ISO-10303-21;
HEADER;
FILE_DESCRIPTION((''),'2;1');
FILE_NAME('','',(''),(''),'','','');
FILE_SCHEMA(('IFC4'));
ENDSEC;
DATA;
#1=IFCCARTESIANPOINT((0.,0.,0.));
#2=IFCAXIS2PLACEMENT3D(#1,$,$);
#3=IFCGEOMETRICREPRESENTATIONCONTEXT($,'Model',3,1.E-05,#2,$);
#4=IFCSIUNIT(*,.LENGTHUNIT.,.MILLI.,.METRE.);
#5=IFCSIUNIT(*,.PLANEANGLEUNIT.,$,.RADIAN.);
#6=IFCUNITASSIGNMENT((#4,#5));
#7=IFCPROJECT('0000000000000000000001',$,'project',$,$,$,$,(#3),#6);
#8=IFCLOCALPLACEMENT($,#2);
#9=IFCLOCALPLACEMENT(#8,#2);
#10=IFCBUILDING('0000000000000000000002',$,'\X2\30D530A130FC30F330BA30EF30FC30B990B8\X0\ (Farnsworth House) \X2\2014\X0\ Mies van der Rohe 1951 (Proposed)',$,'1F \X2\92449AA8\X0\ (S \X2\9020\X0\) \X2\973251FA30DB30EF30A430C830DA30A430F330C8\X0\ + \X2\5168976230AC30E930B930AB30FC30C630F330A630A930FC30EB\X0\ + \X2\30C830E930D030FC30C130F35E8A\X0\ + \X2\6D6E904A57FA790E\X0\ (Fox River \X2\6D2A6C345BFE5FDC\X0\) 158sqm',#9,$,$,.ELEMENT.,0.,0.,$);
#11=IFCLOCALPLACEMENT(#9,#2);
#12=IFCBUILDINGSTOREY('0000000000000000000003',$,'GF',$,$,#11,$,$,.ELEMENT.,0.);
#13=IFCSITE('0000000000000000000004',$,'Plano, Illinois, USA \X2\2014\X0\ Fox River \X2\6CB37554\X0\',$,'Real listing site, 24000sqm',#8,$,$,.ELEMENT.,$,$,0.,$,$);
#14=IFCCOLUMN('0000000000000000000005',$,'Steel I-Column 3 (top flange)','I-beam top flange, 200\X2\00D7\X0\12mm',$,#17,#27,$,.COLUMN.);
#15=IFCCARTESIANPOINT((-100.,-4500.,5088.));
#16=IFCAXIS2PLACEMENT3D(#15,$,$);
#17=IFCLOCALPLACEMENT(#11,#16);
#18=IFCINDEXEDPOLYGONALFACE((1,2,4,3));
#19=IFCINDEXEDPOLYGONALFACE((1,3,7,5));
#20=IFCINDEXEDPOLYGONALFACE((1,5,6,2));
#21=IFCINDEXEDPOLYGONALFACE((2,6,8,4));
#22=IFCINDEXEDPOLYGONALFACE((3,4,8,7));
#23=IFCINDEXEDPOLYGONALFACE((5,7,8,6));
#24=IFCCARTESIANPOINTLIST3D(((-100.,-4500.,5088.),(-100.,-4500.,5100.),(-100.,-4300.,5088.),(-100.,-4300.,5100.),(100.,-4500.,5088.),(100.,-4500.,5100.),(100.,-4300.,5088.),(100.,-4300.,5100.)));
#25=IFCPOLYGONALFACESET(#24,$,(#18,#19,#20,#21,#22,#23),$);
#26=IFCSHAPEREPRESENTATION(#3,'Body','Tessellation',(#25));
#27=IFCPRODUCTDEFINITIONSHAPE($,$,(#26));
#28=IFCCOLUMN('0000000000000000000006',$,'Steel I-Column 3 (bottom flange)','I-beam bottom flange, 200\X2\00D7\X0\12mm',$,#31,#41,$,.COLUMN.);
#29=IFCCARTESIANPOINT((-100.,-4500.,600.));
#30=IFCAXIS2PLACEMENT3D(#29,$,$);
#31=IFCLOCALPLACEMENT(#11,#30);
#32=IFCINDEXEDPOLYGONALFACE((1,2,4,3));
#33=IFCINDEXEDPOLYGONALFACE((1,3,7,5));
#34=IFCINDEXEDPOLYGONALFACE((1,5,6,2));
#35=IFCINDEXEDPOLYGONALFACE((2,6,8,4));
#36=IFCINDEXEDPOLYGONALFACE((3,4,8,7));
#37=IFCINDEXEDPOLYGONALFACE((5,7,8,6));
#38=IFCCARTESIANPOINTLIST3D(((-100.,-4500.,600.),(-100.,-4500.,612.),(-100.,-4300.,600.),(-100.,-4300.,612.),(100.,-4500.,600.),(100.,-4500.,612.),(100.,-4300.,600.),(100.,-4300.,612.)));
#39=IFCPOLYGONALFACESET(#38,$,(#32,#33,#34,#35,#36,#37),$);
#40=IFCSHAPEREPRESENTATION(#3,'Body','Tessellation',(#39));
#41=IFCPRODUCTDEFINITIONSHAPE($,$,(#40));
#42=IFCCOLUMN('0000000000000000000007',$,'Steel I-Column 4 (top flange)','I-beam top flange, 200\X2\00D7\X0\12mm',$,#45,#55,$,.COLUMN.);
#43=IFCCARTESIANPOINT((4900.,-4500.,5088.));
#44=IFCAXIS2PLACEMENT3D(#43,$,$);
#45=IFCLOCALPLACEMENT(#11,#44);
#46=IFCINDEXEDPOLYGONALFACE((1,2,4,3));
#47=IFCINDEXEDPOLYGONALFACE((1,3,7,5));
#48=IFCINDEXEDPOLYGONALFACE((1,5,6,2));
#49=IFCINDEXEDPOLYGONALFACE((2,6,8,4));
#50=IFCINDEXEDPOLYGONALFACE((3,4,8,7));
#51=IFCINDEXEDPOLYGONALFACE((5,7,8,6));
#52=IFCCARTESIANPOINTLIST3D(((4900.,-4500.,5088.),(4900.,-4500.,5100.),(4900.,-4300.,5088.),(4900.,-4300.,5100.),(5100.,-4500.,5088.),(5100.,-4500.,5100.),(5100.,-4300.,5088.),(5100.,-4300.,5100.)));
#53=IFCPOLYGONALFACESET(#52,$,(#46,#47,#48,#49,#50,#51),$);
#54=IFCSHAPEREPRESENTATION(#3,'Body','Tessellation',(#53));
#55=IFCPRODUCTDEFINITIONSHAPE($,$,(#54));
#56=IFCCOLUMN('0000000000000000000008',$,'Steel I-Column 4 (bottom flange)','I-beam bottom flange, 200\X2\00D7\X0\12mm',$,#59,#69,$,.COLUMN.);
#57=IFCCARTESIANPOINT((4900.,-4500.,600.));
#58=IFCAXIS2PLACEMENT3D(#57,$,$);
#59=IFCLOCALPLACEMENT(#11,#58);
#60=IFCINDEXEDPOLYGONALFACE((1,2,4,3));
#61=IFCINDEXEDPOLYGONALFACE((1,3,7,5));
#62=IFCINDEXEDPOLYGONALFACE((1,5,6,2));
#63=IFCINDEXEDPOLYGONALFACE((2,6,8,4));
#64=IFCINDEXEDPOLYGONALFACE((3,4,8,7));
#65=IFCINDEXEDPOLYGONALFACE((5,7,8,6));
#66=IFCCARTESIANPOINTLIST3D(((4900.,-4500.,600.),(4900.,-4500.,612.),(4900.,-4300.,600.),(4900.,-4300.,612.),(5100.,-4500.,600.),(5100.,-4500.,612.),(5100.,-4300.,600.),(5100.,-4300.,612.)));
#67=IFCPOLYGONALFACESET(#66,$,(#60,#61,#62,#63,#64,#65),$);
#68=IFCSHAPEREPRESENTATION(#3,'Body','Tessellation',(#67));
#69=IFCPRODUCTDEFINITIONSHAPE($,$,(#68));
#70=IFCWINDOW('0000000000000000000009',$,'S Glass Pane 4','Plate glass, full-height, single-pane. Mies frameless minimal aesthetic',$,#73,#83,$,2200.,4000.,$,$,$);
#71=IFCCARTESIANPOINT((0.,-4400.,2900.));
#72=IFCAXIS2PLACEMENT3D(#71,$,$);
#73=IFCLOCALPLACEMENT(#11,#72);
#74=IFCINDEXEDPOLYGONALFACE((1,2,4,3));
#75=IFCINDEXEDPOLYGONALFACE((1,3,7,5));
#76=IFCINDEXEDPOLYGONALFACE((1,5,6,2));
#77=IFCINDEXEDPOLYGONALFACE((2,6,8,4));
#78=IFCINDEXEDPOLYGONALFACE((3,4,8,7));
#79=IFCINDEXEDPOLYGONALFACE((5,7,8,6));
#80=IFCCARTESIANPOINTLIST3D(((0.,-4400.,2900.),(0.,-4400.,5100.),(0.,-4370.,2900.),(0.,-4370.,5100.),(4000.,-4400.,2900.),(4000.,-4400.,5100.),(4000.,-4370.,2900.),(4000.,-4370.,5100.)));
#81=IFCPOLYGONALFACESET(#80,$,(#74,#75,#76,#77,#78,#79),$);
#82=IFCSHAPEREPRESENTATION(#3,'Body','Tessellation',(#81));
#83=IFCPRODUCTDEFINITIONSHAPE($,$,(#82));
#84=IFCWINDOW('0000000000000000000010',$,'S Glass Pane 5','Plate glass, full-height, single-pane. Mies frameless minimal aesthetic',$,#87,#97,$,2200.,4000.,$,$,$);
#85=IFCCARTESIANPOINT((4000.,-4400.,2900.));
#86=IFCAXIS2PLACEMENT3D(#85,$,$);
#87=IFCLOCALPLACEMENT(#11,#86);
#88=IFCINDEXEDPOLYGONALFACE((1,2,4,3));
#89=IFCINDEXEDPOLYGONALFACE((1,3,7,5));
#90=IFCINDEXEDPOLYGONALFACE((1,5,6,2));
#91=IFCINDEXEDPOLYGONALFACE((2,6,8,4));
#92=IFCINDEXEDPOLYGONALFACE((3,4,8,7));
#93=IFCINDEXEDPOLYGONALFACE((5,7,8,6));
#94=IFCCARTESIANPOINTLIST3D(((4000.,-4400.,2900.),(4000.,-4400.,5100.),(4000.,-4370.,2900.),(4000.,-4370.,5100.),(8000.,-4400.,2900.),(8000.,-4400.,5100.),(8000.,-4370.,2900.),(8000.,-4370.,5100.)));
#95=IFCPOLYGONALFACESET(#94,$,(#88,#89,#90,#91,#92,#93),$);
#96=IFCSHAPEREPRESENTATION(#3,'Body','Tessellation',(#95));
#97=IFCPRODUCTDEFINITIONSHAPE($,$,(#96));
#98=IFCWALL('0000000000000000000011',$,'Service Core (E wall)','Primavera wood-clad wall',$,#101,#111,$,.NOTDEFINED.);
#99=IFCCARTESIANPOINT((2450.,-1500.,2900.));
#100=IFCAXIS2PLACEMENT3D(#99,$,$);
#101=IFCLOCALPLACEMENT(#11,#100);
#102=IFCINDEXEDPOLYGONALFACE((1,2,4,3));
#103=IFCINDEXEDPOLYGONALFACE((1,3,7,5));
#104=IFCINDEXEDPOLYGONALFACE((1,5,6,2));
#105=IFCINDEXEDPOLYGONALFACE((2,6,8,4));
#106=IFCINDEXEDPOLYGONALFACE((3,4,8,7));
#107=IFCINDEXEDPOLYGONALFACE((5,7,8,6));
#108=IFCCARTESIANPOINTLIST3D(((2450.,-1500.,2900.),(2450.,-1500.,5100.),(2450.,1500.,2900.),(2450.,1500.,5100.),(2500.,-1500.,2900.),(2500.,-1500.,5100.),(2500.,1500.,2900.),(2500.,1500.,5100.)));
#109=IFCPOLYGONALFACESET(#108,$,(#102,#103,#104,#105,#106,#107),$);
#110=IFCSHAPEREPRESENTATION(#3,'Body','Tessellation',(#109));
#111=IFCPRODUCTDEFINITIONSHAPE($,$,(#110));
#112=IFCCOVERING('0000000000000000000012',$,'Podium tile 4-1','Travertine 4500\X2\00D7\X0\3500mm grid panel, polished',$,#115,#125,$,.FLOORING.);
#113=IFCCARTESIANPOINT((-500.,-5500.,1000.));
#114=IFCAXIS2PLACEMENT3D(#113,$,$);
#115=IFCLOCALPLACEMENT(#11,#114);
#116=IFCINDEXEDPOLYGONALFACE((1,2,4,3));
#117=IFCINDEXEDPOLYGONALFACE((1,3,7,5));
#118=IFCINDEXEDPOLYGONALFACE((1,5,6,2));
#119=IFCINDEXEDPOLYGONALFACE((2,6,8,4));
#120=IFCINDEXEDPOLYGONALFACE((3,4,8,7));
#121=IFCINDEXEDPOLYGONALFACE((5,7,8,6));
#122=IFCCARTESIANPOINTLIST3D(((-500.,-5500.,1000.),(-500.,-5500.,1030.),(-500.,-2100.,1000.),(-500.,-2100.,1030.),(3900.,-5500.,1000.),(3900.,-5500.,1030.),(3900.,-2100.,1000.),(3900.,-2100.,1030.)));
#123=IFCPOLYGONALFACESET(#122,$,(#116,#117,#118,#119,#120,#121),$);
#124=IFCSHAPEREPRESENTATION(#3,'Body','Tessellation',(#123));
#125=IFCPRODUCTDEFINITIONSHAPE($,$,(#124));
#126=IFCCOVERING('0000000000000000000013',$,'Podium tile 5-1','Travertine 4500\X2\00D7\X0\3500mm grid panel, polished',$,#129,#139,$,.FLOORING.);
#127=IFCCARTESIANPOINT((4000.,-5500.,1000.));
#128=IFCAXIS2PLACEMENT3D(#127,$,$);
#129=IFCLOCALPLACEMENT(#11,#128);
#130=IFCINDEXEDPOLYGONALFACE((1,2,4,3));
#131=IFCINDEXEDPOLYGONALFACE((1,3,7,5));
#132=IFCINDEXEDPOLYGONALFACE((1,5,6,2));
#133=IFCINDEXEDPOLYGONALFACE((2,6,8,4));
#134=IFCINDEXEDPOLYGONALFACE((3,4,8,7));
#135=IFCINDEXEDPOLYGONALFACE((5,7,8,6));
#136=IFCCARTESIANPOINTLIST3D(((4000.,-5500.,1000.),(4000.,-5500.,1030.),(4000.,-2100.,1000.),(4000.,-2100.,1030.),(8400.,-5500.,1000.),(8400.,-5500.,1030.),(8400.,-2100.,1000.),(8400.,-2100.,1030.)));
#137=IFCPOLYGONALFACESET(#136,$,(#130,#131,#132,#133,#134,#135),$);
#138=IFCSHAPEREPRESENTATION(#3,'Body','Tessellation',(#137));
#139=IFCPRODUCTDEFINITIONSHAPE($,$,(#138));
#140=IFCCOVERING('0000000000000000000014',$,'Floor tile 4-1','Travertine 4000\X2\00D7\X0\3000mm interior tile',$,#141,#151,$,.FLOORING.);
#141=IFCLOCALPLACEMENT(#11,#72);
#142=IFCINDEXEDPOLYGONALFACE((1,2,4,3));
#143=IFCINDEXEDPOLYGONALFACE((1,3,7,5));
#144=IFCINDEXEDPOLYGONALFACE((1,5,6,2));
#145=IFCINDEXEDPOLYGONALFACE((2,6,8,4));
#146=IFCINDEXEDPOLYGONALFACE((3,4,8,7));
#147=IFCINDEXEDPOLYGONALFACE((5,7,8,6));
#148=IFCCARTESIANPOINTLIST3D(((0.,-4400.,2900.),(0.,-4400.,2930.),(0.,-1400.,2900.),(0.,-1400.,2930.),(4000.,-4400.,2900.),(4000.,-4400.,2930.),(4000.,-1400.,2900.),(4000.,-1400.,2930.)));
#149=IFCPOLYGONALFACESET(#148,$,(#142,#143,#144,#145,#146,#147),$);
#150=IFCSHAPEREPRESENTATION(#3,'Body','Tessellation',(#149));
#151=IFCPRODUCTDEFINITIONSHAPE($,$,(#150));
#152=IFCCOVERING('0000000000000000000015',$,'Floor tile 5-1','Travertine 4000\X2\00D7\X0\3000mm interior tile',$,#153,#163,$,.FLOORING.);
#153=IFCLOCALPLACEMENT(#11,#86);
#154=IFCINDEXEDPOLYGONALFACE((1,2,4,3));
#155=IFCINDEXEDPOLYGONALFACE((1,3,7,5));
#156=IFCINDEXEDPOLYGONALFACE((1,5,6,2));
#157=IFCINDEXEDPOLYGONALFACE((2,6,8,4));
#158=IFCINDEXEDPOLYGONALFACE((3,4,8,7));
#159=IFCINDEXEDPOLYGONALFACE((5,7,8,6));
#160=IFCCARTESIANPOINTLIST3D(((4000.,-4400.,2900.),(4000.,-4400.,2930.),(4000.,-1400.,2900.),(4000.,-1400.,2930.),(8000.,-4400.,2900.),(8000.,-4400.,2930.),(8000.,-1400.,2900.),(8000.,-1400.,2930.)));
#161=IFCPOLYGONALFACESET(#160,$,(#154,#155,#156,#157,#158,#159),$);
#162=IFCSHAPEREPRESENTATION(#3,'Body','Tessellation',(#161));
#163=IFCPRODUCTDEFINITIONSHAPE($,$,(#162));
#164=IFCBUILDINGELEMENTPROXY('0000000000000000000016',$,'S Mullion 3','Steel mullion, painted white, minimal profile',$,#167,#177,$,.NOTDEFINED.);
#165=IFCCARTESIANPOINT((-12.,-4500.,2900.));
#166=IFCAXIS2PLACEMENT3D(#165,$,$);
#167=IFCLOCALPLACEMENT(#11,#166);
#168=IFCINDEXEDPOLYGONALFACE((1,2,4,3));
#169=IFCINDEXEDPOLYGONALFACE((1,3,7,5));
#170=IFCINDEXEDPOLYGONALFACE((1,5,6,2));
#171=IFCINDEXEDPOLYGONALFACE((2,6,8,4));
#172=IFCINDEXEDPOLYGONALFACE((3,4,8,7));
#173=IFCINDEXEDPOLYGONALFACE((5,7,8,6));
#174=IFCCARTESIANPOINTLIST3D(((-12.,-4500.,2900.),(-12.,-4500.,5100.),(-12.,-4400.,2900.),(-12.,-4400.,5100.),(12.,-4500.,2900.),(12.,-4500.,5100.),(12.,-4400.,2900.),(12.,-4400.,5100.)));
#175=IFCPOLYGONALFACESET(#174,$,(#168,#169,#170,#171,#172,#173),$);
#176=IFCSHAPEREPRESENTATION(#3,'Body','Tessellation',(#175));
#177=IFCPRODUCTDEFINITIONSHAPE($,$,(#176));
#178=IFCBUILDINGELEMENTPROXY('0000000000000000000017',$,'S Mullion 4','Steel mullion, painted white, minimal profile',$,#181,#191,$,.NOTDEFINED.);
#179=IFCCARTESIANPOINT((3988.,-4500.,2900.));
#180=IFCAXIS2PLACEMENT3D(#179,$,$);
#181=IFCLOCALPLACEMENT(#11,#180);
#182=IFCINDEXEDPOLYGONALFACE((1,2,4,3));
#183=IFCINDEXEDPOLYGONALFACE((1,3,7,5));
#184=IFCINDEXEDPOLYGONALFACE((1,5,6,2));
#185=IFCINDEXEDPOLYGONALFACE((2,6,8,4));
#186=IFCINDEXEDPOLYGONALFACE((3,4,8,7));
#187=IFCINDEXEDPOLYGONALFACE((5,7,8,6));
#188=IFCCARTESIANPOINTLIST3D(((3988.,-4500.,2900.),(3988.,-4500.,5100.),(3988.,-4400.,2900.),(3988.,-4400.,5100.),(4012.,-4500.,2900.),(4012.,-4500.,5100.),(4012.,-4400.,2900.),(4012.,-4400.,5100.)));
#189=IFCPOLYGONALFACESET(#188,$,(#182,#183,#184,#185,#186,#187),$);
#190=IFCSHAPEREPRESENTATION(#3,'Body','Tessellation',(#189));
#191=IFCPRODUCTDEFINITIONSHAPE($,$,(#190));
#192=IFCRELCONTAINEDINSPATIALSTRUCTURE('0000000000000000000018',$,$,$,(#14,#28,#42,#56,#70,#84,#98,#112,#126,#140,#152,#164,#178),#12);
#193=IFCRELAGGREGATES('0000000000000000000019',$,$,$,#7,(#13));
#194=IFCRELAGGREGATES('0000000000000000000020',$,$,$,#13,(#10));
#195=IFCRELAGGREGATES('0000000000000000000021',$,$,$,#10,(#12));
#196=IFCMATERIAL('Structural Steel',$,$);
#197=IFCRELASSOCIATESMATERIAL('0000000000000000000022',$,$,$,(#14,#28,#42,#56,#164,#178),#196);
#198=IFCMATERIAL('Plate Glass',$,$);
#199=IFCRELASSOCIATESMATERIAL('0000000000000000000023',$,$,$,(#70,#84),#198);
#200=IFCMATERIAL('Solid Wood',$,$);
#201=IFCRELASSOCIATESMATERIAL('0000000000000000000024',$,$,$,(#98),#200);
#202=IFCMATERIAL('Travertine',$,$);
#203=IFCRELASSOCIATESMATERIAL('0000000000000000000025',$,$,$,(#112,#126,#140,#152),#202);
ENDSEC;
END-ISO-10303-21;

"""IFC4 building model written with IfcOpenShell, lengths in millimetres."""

from ifc_helpers import new_model, si_unit, frame, frame_2d, origin, place, context, project, spatial, rectangle, extrude, material, element, save


model = new_model("IFC4")

# Units and contexts
model_context = context("Model", 3, precision=1e-05, world=origin())
ifc_project = project(units=[si_unit("LENGTHUNIT", "METRE", prefix="MILLI"), si_unit("PLANEANGLEUNIT", "RADIAN")], contexts=[model_context])

# Site, building, storey
site_placement = place(None, origin())
site = spatial("IfcSite", under=ifc_project, at=site_placement, Name="Plano, Illinois, USA — Fox River 河畔", ObjectType="Real listing site, 24000sqm", CompositionType="ELEMENT", RefElevation=0.0)
building_placement = place(site_placement, origin())
building = spatial("IfcBuilding", under=site, at=building_placement, Name="ファーンズワース邸 (Farnsworth House) — Mies van der Rohe 1951 (Proposed)", ObjectType="1F 鉄骨 (S 造) 露出ホワイトペイント + 全面ガラスカーテンウォール + トラバーチン床 + 浮遊基礎 (Fox River 洪水対応) 158sqm", CompositionType="ELEMENT", ElevationOfRefHeight=0.0, ElevationOfTerrain=0.0)
storey_placement = place(building_placement, origin())
storey = spatial("IfcBuildingStorey", under=building, at=storey_placement, Name="GF", CompositionType="ELEMENT", Elevation=0.0)

# Columns
ifc_material_1 = material(Name="Structural Steel")
column_1_placement = place(storey_placement, frame((-100.0, -4500.0, 5088.0)))
element("IfcColumn", 1, at=column_1_placement, inside=storey, material=ifc_material_1, Name="Steel I-Column 3 (top flange)", Description="I-beam top flange, 200×12mm", PredefinedType="COLUMN", context=model_context, shape_type="SweptSolid", body=[
    extrude(rectangle(XDim=200.0, YDim=200.0, at=frame_2d((100.0, 100.0))), frame((-100.0, -4500.0, 5088.0)), (0.0, 0.0, 1.0), 12.0),
])
column_2_placement = place(storey_placement, frame((-100.0, -4500.0, 600.0)))
element("IfcColumn", 2, at=column_2_placement, inside=storey, material=ifc_material_1, Name="Steel I-Column 3 (bottom flange)", Description="I-beam bottom flange, 200×12mm", PredefinedType="COLUMN", context=model_context, shape_type="SweptSolid", body=[
    extrude(rectangle(XDim=200.0, YDim=200.0, at=frame_2d((100.0, 100.0))), frame((-100.0, -4500.0, 600.0)), (0.0, 0.0, 1.0), 12.0),
])
column_3_placement = place(storey_placement, frame((4900.0, -4500.0, 5088.0)))
element("IfcColumn", 3, at=column_3_placement, inside=storey, material=ifc_material_1, Name="Steel I-Column 4 (top flange)", Description="I-beam top flange, 200×12mm", PredefinedType="COLUMN", context=model_context, shape_type="SweptSolid", body=[
    extrude(rectangle(XDim=200.0, YDim=200.0, at=frame_2d((100.0, 100.0))), frame((4900.0, -4500.0, 5088.0)), (0.0, 0.0, 1.0), 12.0),
])
column_4_placement = place(storey_placement, frame((4900.0, -4500.0, 600.0)))
element("IfcColumn", 4, at=column_4_placement, inside=storey, material=ifc_material_1, Name="Steel I-Column 4 (bottom flange)", Description="I-beam bottom flange, 200×12mm", PredefinedType="COLUMN", context=model_context, shape_type="SweptSolid", body=[
    extrude(rectangle(XDim=200.0, YDim=200.0, at=frame_2d((100.0, 100.0))), frame((4900.0, -4500.0, 600.0)), (0.0, 0.0, 1.0), 12.0),
])

# Windows
ifc_material_2 = material(Name="Plate Glass")
window_1_placement = place(storey_placement, frame((0.0, -4400.0, 2900.0)))
element("IfcWindow", 5, at=window_1_placement, inside=storey, material=ifc_material_2, Name="S Glass Pane 4", Description="Plate glass, full-height, single-pane. Mies frameless minimal aesthetic", OverallHeight=2200.0, OverallWidth=4000.0, context=model_context, shape_type="SweptSolid", body=[
    extrude(rectangle(XDim=4000.0, YDim=30.0, at=frame_2d((2000.0, 15.0))), frame((0.0, -4400.0, 2900.0)), (0.0, 0.0, 1.0), 2200.0),
])
window_2_placement = place(storey_placement, frame((4000.0, -4400.0, 2900.0)))
element("IfcWindow", 6, at=window_2_placement, inside=storey, material=ifc_material_2, Name="S Glass Pane 5", Description="Plate glass, full-height, single-pane. Mies frameless minimal aesthetic", OverallHeight=2200.0, OverallWidth=4000.0, context=model_context, shape_type="SweptSolid", body=[
    extrude(rectangle(XDim=4000.0, YDim=30.0, at=frame_2d((2000.0, 15.0))), frame((4000.0, -4400.0, 2900.0)), (0.0, 0.0, 1.0), 2200.0),
])

# Wall
ifc_material_3 = material(Name="Solid Wood")
wall_placement = place(storey_placement, frame((2450.0, -1500.0, 2900.0)))
element("IfcWall", 7, at=wall_placement, inside=storey, material=ifc_material_3, Name="Service Core (E wall)", Description="Primavera wood-clad wall", PredefinedType="NOTDEFINED", context=model_context, shape_type="SweptSolid", body=[
    extrude(rectangle(XDim=50.0, YDim=3000.0, at=frame_2d((25.0, 1500.0))), frame((2450.0, -1500.0, 2900.0)), (0.0, 0.0, 1.0), 2200.0),
])

# Coverings
ifc_material_4 = material(Name="Travertine")
covering_1_placement = place(storey_placement, frame((-500.0, -5500.0, 1000.0)))
element("IfcCovering", 8, at=covering_1_placement, inside=storey, material=ifc_material_4, Name="Podium tile 4-1", Description="Travertine 4500×3500mm grid panel, polished", PredefinedType="FLOORING", context=model_context, shape_type="SweptSolid", body=[
    extrude(rectangle(XDim=4400.0, YDim=3400.0, at=frame_2d((2200.0, 1700.0))), frame((-500.0, -5500.0, 1000.0)), (0.0, 0.0, 1.0), 30.0),
])
covering_2_placement = place(storey_placement, frame((4000.0, -5500.0, 1000.0)))
element("IfcCovering", 9, at=covering_2_placement, inside=storey, material=ifc_material_4, Name="Podium tile 5-1", Description="Travertine 4500×3500mm grid panel, polished", PredefinedType="FLOORING", context=model_context, shape_type="SweptSolid", body=[
    extrude(rectangle(XDim=4400.0, YDim=3400.0, at=frame_2d((2200.0, 1700.0))), frame((4000.0, -5500.0, 1000.0)), (0.0, 0.0, 1.0), 30.0),
])
covering_3_placement = place(storey_placement, frame((0.0, -4400.0, 2900.0)))
element("IfcCovering", 10, at=covering_3_placement, inside=storey, material=ifc_material_4, Name="Floor tile 4-1", Description="Travertine 4000×3000mm interior tile", PredefinedType="FLOORING", context=model_context, shape_type="SweptSolid", body=[
    extrude(rectangle(XDim=4000.0, YDim=3000.0, at=frame_2d((2000.0, 1500.0))), frame((0.0, -4400.0, 2900.0)), (0.0, 0.0, 1.0), 30.0),
])
covering_4_placement = place(storey_placement, frame((4000.0, -4400.0, 2900.0)))
element("IfcCovering", 11, at=covering_4_placement, inside=storey, material=ifc_material_4, Name="Floor tile 5-1", Description="Travertine 4000×3000mm interior tile", PredefinedType="FLOORING", context=model_context, shape_type="SweptSolid", body=[
    extrude(rectangle(XDim=4000.0, YDim=3000.0, at=frame_2d((2000.0, 1500.0))), frame((4000.0, -4400.0, 2900.0)), (0.0, 0.0, 1.0), 30.0),
])

# Building element proxies
proxy_1_placement = place(storey_placement, frame((-12.0, -4500.0, 2900.0)))
element("IfcBuildingElementProxy", 12, at=proxy_1_placement, inside=storey, material=ifc_material_1, Name="S Mullion 3", Description="Steel mullion, painted white, minimal profile", PredefinedType="NOTDEFINED", context=model_context, shape_type="SweptSolid", body=[
    extrude(rectangle(XDim=24.0, YDim=100.0, at=frame_2d((12.0, 50.0))), frame((-12.0, -4500.0, 2900.0)), (0.0, 0.0, 1.0), 2200.0),
])
proxy_2_placement = place(storey_placement, frame((3988.0, -4500.0, 2900.0)))
element("IfcBuildingElementProxy", 13, at=proxy_2_placement, inside=storey, material=ifc_material_1, Name="S Mullion 4", Description="Steel mullion, painted white, minimal profile", PredefinedType="NOTDEFINED", context=model_context, shape_type="SweptSolid", body=[
    extrude(rectangle(XDim=24.0, YDim=100.0, at=frame_2d((12.0, 50.0))), frame((3988.0, -4500.0, 2900.0)), (0.0, 0.0, 1.0), 2200.0),
])

save(model, "model.ifc")
